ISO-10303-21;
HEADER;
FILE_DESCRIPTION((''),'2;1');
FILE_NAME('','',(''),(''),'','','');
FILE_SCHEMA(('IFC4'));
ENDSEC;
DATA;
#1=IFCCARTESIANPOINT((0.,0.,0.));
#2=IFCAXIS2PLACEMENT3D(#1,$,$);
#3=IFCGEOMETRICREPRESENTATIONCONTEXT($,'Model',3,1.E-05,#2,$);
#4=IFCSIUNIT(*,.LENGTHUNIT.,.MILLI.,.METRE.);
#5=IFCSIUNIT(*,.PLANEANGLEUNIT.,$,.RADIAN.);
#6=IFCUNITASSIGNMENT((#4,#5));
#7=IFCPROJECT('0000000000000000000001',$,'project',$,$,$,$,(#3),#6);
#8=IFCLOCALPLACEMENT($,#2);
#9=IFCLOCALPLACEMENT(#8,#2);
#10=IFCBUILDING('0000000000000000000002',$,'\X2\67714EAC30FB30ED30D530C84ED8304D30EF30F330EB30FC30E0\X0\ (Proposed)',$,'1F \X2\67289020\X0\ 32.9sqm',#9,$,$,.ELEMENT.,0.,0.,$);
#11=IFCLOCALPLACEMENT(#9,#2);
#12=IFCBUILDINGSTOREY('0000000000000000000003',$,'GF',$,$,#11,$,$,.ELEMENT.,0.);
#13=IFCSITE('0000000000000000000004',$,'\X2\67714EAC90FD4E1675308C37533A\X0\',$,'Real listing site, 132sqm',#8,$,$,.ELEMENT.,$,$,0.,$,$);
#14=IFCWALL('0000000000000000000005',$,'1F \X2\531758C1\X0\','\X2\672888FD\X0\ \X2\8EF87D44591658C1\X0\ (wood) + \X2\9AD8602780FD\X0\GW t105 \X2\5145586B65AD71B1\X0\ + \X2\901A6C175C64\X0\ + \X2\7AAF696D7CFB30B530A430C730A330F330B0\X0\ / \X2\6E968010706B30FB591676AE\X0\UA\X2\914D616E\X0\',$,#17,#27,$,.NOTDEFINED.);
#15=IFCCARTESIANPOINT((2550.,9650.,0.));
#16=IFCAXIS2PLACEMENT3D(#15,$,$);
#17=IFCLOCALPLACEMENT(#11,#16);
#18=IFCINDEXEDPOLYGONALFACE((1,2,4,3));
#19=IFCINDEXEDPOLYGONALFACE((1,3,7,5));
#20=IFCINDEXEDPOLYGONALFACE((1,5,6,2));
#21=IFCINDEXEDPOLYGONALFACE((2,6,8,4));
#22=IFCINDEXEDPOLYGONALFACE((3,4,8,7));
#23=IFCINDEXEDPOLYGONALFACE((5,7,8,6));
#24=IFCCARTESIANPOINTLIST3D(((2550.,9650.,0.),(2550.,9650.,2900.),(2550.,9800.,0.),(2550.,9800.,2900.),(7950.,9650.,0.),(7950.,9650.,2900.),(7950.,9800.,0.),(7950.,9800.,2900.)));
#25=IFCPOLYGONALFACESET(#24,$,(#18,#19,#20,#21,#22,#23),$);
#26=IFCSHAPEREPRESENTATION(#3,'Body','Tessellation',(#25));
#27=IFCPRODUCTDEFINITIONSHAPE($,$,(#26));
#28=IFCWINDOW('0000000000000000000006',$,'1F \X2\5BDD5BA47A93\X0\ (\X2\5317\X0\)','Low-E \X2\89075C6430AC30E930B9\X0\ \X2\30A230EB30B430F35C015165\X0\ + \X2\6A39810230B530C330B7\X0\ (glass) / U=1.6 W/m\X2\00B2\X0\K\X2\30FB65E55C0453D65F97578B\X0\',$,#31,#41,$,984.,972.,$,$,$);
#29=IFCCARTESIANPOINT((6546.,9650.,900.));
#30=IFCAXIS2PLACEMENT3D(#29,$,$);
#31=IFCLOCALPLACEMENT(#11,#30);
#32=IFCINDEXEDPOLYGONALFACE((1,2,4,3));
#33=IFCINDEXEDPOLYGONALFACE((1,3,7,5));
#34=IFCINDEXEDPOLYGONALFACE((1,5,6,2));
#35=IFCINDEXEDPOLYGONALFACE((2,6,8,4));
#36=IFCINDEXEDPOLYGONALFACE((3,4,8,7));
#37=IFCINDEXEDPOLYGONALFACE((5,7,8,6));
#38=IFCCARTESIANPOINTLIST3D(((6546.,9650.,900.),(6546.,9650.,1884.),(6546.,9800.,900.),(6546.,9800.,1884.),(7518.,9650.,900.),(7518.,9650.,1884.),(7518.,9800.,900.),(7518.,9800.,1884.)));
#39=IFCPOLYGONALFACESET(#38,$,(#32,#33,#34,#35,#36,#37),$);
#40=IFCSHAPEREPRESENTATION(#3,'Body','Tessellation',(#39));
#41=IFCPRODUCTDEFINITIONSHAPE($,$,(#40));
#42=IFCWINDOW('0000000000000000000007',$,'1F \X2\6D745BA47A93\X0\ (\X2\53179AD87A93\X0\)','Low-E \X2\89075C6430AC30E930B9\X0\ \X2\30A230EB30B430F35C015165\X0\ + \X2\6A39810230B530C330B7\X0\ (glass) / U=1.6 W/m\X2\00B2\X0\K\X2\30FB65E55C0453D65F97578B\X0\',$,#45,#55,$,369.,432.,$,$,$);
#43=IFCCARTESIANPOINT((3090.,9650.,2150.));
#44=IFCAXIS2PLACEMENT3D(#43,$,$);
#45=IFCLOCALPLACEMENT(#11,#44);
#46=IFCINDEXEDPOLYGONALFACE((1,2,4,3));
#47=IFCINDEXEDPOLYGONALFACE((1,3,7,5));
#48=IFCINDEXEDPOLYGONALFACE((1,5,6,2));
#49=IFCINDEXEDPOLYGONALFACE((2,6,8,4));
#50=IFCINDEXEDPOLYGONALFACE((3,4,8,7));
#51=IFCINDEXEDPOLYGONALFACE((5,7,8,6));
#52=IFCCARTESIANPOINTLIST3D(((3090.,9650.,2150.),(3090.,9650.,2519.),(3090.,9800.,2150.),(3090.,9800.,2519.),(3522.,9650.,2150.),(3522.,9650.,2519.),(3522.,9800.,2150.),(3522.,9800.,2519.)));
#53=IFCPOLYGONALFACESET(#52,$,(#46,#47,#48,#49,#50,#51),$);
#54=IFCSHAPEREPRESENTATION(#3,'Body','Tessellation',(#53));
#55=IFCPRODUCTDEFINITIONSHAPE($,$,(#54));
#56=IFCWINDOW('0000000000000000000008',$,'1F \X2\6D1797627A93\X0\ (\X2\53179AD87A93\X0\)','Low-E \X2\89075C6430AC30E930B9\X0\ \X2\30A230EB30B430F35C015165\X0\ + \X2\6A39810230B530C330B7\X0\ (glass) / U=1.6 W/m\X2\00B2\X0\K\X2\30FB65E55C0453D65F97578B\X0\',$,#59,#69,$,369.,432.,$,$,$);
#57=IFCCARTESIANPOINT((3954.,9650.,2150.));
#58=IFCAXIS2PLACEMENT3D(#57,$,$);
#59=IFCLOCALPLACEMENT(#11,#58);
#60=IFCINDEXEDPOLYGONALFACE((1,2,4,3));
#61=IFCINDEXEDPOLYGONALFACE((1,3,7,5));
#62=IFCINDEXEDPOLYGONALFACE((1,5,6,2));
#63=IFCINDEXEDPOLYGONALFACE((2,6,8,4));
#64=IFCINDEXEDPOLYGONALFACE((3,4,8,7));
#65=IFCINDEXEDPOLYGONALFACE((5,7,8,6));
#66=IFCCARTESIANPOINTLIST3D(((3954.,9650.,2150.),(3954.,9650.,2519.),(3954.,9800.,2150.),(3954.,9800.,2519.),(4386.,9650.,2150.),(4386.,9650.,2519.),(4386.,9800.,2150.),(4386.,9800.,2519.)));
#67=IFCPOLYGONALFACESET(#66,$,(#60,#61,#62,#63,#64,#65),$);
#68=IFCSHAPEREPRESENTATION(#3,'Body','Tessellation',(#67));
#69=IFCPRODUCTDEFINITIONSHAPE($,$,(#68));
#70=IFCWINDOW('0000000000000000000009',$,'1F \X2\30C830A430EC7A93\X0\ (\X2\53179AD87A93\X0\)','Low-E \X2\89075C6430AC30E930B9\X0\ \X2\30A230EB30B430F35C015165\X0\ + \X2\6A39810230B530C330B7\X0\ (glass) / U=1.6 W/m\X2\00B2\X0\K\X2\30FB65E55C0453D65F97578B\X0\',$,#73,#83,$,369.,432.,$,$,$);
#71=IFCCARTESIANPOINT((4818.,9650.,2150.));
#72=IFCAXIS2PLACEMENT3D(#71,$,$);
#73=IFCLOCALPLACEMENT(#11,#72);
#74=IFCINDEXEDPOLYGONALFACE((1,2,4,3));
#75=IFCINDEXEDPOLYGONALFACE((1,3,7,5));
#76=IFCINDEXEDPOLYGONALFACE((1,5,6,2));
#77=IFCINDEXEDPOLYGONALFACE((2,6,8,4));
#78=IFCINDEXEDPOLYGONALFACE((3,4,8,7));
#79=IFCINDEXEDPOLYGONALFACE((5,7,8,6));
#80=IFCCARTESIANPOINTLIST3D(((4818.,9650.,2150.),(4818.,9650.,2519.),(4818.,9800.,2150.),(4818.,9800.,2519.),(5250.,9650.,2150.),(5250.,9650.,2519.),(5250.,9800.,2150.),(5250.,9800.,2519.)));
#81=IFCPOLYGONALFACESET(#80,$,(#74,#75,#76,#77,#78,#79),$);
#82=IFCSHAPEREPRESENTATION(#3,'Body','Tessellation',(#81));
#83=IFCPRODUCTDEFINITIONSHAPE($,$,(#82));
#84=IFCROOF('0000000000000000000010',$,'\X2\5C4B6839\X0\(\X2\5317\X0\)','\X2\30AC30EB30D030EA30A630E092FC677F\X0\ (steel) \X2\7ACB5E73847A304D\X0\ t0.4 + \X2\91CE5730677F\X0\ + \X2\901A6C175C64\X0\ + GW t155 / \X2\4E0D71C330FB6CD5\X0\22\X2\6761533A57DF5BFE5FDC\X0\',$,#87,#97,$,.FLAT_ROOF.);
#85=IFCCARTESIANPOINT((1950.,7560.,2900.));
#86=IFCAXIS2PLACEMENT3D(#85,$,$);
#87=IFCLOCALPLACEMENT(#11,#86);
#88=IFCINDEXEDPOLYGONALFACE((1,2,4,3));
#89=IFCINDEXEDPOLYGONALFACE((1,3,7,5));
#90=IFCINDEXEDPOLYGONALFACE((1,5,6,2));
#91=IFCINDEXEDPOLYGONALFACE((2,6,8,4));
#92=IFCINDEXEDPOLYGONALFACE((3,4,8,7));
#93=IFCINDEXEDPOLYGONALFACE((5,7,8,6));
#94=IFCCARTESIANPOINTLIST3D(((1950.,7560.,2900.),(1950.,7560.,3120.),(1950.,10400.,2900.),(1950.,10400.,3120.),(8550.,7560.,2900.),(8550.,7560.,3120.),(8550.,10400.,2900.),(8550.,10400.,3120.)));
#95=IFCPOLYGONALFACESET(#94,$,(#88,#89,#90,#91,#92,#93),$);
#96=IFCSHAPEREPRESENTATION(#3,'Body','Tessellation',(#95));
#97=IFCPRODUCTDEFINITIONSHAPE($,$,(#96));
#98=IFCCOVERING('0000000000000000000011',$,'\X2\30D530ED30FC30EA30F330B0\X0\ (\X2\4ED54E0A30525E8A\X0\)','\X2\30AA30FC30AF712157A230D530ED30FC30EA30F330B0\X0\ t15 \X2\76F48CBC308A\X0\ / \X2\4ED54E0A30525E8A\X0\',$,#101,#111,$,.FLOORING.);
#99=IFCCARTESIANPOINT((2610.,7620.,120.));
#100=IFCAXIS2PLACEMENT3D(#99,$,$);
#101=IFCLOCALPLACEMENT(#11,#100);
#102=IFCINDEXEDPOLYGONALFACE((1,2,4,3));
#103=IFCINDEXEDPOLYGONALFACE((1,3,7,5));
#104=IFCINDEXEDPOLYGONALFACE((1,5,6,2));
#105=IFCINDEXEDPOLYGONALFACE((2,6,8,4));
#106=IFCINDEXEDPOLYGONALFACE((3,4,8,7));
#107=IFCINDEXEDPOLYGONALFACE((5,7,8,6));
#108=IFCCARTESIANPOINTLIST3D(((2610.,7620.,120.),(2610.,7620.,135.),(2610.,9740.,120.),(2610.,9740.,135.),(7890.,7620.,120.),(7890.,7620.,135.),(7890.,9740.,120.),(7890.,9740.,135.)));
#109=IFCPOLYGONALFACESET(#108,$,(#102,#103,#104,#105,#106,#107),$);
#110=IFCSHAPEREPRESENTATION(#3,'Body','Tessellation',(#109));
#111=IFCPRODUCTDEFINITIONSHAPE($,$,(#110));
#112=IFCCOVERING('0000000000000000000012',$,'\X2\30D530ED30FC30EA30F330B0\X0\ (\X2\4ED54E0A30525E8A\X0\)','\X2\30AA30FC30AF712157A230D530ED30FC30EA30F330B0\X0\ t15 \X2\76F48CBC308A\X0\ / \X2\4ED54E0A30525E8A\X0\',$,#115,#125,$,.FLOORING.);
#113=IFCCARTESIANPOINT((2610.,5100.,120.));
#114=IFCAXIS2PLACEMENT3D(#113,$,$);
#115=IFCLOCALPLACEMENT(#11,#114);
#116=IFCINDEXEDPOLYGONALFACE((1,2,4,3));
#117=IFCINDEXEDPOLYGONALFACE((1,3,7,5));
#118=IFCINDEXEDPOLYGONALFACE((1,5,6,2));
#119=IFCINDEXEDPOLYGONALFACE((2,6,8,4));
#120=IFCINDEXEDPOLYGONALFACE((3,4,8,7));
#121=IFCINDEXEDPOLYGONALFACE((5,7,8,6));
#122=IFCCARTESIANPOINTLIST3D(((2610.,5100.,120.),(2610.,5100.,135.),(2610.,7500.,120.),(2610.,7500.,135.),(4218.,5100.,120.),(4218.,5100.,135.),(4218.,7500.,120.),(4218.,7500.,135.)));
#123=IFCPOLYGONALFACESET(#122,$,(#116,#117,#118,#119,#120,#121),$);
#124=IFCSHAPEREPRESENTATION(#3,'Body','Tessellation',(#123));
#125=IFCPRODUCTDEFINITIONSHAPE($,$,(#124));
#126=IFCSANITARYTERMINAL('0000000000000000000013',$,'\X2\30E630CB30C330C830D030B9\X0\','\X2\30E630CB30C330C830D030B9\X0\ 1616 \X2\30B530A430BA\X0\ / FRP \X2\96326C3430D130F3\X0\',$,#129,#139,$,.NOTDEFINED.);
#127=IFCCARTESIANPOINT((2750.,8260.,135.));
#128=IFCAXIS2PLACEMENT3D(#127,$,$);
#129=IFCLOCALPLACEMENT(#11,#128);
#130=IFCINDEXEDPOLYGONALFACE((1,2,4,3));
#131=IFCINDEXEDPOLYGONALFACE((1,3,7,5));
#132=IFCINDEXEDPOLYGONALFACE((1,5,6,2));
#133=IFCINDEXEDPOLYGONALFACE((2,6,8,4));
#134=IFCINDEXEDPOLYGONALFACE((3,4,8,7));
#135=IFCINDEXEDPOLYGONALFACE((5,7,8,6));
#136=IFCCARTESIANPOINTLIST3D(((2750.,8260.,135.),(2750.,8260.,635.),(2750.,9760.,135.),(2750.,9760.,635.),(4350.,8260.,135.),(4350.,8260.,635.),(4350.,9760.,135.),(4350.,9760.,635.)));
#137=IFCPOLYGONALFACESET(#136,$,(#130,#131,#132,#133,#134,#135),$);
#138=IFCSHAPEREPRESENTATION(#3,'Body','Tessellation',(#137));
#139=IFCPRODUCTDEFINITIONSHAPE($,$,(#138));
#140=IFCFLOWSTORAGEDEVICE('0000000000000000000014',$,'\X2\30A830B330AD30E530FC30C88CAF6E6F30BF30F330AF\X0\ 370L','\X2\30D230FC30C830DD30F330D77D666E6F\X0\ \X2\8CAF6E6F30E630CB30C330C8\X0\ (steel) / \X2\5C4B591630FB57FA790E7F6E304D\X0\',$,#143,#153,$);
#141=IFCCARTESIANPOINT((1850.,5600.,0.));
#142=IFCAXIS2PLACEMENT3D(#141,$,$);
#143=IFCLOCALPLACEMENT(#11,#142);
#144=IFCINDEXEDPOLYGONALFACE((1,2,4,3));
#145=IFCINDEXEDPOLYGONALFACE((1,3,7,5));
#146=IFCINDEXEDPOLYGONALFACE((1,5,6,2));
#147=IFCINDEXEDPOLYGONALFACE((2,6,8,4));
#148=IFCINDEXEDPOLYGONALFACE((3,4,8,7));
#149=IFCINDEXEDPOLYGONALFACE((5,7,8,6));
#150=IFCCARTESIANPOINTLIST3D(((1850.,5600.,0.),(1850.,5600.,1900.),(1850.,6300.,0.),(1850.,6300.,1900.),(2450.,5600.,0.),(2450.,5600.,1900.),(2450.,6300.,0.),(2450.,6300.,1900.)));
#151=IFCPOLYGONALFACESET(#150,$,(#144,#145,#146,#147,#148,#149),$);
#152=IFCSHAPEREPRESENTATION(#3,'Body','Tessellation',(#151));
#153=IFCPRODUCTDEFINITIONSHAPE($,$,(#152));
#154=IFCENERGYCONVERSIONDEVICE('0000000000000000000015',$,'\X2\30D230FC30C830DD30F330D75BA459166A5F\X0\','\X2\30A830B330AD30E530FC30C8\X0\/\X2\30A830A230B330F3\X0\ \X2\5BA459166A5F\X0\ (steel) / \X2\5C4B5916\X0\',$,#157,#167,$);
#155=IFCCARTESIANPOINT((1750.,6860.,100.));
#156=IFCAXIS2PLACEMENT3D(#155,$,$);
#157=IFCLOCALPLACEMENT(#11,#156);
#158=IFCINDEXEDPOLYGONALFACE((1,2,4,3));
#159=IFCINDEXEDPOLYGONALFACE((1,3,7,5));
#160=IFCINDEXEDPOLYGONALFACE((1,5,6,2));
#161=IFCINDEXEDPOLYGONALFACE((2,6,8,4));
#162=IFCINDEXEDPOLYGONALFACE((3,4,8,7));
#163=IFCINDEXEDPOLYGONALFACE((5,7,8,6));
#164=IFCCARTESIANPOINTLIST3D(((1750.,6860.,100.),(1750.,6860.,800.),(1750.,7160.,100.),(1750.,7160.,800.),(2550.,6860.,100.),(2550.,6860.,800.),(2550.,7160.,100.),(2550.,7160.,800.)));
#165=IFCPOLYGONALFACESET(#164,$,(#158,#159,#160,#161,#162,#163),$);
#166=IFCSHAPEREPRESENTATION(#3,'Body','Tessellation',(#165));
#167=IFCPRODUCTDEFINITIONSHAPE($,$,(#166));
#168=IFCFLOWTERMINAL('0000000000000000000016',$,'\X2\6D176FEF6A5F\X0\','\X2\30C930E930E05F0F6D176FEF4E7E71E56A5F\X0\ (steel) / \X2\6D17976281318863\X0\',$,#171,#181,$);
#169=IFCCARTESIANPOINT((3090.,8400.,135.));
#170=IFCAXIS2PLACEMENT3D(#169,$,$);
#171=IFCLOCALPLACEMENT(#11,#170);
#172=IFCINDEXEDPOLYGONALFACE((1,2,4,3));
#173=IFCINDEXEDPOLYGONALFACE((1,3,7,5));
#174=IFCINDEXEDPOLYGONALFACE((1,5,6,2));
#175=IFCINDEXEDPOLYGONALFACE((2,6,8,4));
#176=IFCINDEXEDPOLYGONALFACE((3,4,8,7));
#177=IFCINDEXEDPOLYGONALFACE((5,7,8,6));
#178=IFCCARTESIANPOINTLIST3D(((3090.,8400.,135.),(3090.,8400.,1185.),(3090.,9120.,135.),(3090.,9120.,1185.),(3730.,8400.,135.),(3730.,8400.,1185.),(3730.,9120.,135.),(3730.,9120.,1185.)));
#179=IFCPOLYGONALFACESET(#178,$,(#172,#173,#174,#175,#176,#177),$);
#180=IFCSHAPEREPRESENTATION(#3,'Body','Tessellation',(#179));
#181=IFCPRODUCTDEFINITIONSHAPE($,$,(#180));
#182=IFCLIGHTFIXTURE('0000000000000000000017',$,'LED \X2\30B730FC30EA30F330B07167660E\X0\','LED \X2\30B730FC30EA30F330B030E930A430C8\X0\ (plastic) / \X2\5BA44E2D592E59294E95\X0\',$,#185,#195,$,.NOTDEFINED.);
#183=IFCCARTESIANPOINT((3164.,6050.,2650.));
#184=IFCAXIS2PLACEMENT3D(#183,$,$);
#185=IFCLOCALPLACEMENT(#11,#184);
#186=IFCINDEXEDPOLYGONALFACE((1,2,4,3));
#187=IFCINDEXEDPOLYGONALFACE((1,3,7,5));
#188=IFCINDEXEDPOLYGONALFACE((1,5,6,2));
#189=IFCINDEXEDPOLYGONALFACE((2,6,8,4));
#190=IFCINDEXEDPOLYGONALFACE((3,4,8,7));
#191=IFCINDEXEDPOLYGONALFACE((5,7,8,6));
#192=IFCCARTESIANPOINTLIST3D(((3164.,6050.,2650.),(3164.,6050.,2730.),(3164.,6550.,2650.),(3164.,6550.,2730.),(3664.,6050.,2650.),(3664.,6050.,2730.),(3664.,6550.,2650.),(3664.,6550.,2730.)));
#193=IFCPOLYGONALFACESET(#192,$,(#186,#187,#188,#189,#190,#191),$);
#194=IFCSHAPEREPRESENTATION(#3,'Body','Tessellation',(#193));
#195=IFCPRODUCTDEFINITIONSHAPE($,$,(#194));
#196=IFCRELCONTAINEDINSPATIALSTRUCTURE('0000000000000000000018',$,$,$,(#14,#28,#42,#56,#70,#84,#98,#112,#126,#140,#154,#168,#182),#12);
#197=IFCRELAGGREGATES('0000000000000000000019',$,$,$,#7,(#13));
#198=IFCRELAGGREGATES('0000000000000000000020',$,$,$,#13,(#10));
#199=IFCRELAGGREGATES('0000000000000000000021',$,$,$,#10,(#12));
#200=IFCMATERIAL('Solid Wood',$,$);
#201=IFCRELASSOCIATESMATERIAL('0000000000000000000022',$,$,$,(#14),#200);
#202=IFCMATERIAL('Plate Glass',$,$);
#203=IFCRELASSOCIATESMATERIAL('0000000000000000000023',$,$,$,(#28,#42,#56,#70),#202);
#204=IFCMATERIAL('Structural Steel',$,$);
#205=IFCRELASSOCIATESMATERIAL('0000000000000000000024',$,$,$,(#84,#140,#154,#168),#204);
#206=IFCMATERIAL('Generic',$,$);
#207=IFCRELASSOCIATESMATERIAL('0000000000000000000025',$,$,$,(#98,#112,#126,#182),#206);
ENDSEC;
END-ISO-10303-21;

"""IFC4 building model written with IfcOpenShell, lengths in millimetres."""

from ifc_helpers import new_model, si_unit, frame, frame_2d, origin, place, context, project, spatial, rectangle, extrude, material, element, fill, save


model = new_model("IFC4")

# Units and contexts
model_context = context("Model", 3, precision=1e-05, world=origin())
ifc_project = project(units=[si_unit("LENGTHUNIT", "METRE", prefix="MILLI"), si_unit("PLANEANGLEUNIT", "RADIAN")], contexts=[model_context])

# Site, building, storey
site_placement = place(None, origin())
site = spatial("IfcSite", under=ifc_project, at=site_placement, Name="東京都世田谷区", ObjectType="Real listing site, 132sqm", CompositionType="ELEMENT", RefElevation=0.0)
building_placement = place(site_placement, origin())
building = spatial("IfcBuilding", under=site, at=building_placement, Name="東京・ロフト付きワンルーム (Proposed)", ObjectType="1F 木造 32.9sqm", CompositionType="ELEMENT", ElevationOfRefHeight=0.0, ElevationOfTerrain=0.0)
storey_placement = place(building_placement, origin())
storey = spatial("IfcBuildingStorey", under=building, at=storey_placement, Name="GF", CompositionType="ELEMENT", Elevation=0.0)

# Shared definitions
ifc_material_1 = material(Name="Solid Wood")

# Wall, openings, windows
wall_1_placement = place(storey_placement, frame((2550.0, 9650.0, 0.0)))
wall_1 = element("IfcWall", 1, at=wall_1_placement, inside=storey, material=ifc_material_1, Name="1F 北壁", Description="木製 軸組外壁 (wood) + 高性能GW t105 充填断熱 + 通気層 + 窯業系サイディング / 準耐火・外皮UA配慮", PredefinedType="NOTDEFINED", context=model_context, shape_type="SweptSolid", body=[
    extrude(rectangle(XDim=5400.0, YDim=150.0, at=frame_2d((2700.0, 75.0))), frame((2550.0, 9650.0, 0.0)), (0.0, 0.0, 1.0), 2900.0),
])
opening_1_placement = place(storey_placement, frame((6546.0, 9650.0, 900.0)))
opening_1 = element("IfcOpeningElement", 2, at=opening_1_placement, cuts=wall_1, PredefinedType="NOTDEFINED", context=model_context, shape_type="SweptSolid", body=[
    extrude(rectangle(XDim=972.0, YDim=150.0, at=frame_2d((486.0, 75.0))), frame((6546.0, 9650.0, 900.0)), (0.0, 0.0, 1.0), 984.0),
])
opening_2_placement = place(storey_placement, frame((3090.0, 9650.0, 2150.0)))
opening_2 = element("IfcOpeningElement", 3, at=opening_2_placement, cuts=wall_1, PredefinedType="NOTDEFINED", context=model_context, shape_type="SweptSolid", body=[
    extrude(rectangle(XDim=432.0, YDim=150.0, at=frame_2d((216.0, 75.0))), frame((3090.0, 9650.0, 2150.0)), (0.0, 0.0, 1.0), 369.0),
])
opening_3_placement = place(storey_placement, frame((3954.0, 9650.0, 2150.0)))
opening_3 = element("IfcOpeningElement", 4, at=opening_3_placement, cuts=wall_1, PredefinedType="NOTDEFINED", context=model_context, shape_type="SweptSolid", body=[
    extrude(rectangle(XDim=432.0, YDim=150.0, at=frame_2d((216.0, 75.0))), frame((3954.0, 9650.0, 2150.0)), (0.0, 0.0, 1.0), 369.0),
])
opening_4_placement = place(storey_placement, frame((4818.0, 9650.0, 2150.0)))
opening_4 = element("IfcOpeningElement", 5, at=opening_4_placement, cuts=wall_1, PredefinedType="NOTDEFINED", context=model_context, shape_type="SweptSolid", body=[
    extrude(rectangle(XDim=432.0, YDim=150.0, at=frame_2d((216.0, 75.0))), frame((4818.0, 9650.0, 2150.0)), (0.0, 0.0, 1.0), 369.0),
])
ifc_material_2 = material(Name="Plate Glass")
window_1_placement = place(storey_placement, frame((6546.0, 9650.0, 900.0)))
window_1 = element("IfcWindow", 6, at=window_1_placement, inside=storey, material=ifc_material_2, Name="1F 寝室窓 (北)", Description="Low-E 複層ガラス アルゴン封入 + 樹脂サッシ (glass) / U=1.6 W/m²K・日射取得型", OverallHeight=984.0, OverallWidth=972.0, context=model_context, shape_type="SweptSolid", body=[
    extrude(rectangle(XDim=972.0, YDim=150.0, at=frame_2d((486.0, 75.0))), frame((6546.0, 9650.0, 900.0)), (0.0, 0.0, 1.0), 984.0),
])
fill(opening_1, window_1)
window_2_placement = place(storey_placement, frame((3090.0, 9650.0, 2150.0)))
window_2 = element("IfcWindow", 7, at=window_2_placement, inside=storey, material=ifc_material_2, Name="1F 浴室窓 (北高窓)", Description="Low-E 複層ガラス アルゴン封入 + 樹脂サッシ (glass) / U=1.6 W/m²K・日射取得型", OverallHeight=369.0, OverallWidth=432.0, context=model_context, shape_type="SweptSolid", body=[
    extrude(rectangle(XDim=432.0, YDim=150.0, at=frame_2d((216.0, 75.0))), frame((3090.0, 9650.0, 2150.0)), (0.0, 0.0, 1.0), 369.0),
])
fill(opening_2, window_2)
window_3_placement = place(storey_placement, frame((3954.0, 9650.0, 2150.0)))
window_3 = element("IfcWindow", 8, at=window_3_placement, inside=storey, material=ifc_material_2, Name="1F 洗面窓 (北高窓)", Description="Low-E 複層ガラス アルゴン封入 + 樹脂サッシ (glass) / U=1.6 W/m²K・日射取得型", OverallHeight=369.0, OverallWidth=432.0, context=model_context, shape_type="SweptSolid", body=[
    extrude(rectangle(XDim=432.0, YDim=150.0, at=frame_2d((216.0, 75.0))), frame((3954.0, 9650.0, 2150.0)), (0.0, 0.0, 1.0), 369.0),
])
fill(opening_3, window_3)
window_4_placement = place(storey_placement, frame((4818.0, 9650.0, 2150.0)))
window_4 = element("IfcWindow", 9, at=window_4_placement, inside=storey, material=ifc_material_2, Name="1F トイレ窓 (北高窓)", Description="Low-E 複層ガラス アルゴン封入 + 樹脂サッシ (glass) / U=1.6 W/m²K・日射取得型", OverallHeight=369.0, OverallWidth=432.0, context=model_context, shape_type="SweptSolid", body=[
    extrude(rectangle(XDim=432.0, YDim=150.0, at=frame_2d((216.0, 75.0))), frame((4818.0, 9650.0, 2150.0)), (0.0, 0.0, 1.0), 369.0),
])
fill(opening_4, window_4)

# Roof
ifc_material_3 = material(Name="Structural Steel")
roof_placement = place(storey_placement, frame((1950.0, 7560.0, 2900.0)))
element("IfcRoof", 10, at=roof_placement, inside=storey, material=ifc_material_3, Name="屋根(北)", Description="ガルバリウム鋼板 (steel) 立平葺き t0.4 + 野地板 + 通気層 + GW t155 / 不燃・法22条区域対応", PredefinedType="FLAT_ROOF", context=model_context, shape_type="SweptSolid", body=[
    extrude(rectangle(XDim=6600.0, YDim=2840.0, at=frame_2d((3300.0, 1420.0))), frame((1950.0, 7560.0, 2900.0)), (0.0, 0.0, 1.0), 220.0),
])

# Coverings
ifc_material_4 = material(Name="Generic")
covering_1_placement = place(storey_placement, frame((2610.0, 7620.0, 120.0)))
element("IfcCovering", 11, at=covering_1_placement, inside=storey, material=ifc_material_4, Name="フローリング (仕上げ床)", Description="オーク無垢フローリング t15 直貼り / 仕上げ床", PredefinedType="FLOORING", context=model_context, shape_type="SweptSolid", body=[
    extrude(rectangle(XDim=5280.0, YDim=2120.0, at=frame_2d((2640.0, 1060.0))), frame((2610.0, 7620.0, 120.0)), (0.0, 0.0, 1.0), 15.0),
])
covering_2_placement = place(storey_placement, frame((2610.0, 5100.0, 120.0)))
element("IfcCovering", 12, at=covering_2_placement, inside=storey, material=ifc_material_4, Name="フローリング (仕上げ床)", Description="オーク無垢フローリング t15 直貼り / 仕上げ床", PredefinedType="FLOORING", context=model_context, shape_type="SweptSolid", body=[
    extrude(rectangle(XDim=1608.0, YDim=2400.0, at=frame_2d((804.0, 1200.0))), frame((2610.0, 5100.0, 120.0)), (0.0, 0.0, 1.0), 15.0),
])

# Sanitary terminal
sanitary_terminal_placement = place(storey_placement, frame((2750.0, 8260.0, 135.0)))
element("IfcSanitaryTerminal", 13, at=sanitary_terminal_placement, inside=storey, material=ifc_material_4, Name="ユニットバス", Description="ユニットバス 1616 サイズ / FRP 防水パン", PredefinedType="NOTDEFINED", context=model_context, shape_type="SweptSolid", body=[
    extrude(rectangle(XDim=1600.0, YDim=1500.0, at=frame_2d((800.0, 750.0))), frame((2750.0, 8260.0, 135.0)), (0.0, 0.0, 1.0), 500.0),
])

# Flow storage device
flow_storage_device_placement = place(storey_placement, frame((1850.0, 5600.0, 0.0)))
element("IfcFlowStorageDevice", 14, at=flow_storage_device_placement, inside=storey, material=ifc_material_3, Name="エコキュート貯湯タンク 370L", Description="ヒートポンプ給湯 貯湯ユニット (steel) / 屋外・基礎置き", context=model_context, shape_type="SweptSolid", body=[
    extrude(rectangle(XDim=600.0, YDim=700.0, at=frame_2d((300.0, 350.0))), frame((1850.0, 5600.0, 0.0)), (0.0, 0.0, 1.0), 1900.0),
])

# Energy conversion device
energy_conversion_device_placement = place(storey_placement, frame((1750.0, 6860.0, 100.0)))
element("IfcEnergyConversionDevice", 15, at=energy_conversion_device_placement, inside=storey, material=ifc_material_3, Name="ヒートポンプ室外機", Description="エコキュート/エアコン 室外機 (steel) / 屋外", context=model_context, shape_type="SweptSolid", body=[
    extrude(rectangle(XDim=800.0, YDim=300.0, at=frame_2d((400.0, 150.0))), frame((1750.0, 6860.0, 100.0)), (0.0, 0.0, 1.0), 700.0),
])

# Flow terminal
flow_terminal_placement = place(storey_placement, frame((3090.0, 8400.0, 135.0)))
element("IfcFlowTerminal", 16, at=flow_terminal_placement, inside=storey, material=ifc_material_3, Name="洗濯機", Description="ドラム式洗濯乾燥機 (steel) / 洗面脱衣", context=model_context, shape_type="SweptSolid", body=[
    extrude(rectangle(XDim=640.0, YDim=720.0, at=frame_2d((320.0, 360.0))), frame((3090.0, 8400.0, 135.0)), (0.0, 0.0, 1.0), 1050.0),
])

# Light fixture
light_fixture_placement = place(storey_placement, frame((3164.0, 6050.0, 2650.0)))
element("IfcLightFixture", 17, at=light_fixture_placement, inside=storey, material=ifc_material_4, Name="LED シーリング照明", Description="LED シーリングライト (plastic) / 室中央天井", PredefinedType="NOTDEFINED", context=model_context, shape_type="SweptSolid", body=[
    extrude(rectangle(XDim=500.0, YDim=500.0, at=frame_2d((250.0, 250.0))), frame((3164.0, 6050.0, 2650.0)), (0.0, 0.0, 1.0), 80.0),
])

save(model, "model.ifc")
